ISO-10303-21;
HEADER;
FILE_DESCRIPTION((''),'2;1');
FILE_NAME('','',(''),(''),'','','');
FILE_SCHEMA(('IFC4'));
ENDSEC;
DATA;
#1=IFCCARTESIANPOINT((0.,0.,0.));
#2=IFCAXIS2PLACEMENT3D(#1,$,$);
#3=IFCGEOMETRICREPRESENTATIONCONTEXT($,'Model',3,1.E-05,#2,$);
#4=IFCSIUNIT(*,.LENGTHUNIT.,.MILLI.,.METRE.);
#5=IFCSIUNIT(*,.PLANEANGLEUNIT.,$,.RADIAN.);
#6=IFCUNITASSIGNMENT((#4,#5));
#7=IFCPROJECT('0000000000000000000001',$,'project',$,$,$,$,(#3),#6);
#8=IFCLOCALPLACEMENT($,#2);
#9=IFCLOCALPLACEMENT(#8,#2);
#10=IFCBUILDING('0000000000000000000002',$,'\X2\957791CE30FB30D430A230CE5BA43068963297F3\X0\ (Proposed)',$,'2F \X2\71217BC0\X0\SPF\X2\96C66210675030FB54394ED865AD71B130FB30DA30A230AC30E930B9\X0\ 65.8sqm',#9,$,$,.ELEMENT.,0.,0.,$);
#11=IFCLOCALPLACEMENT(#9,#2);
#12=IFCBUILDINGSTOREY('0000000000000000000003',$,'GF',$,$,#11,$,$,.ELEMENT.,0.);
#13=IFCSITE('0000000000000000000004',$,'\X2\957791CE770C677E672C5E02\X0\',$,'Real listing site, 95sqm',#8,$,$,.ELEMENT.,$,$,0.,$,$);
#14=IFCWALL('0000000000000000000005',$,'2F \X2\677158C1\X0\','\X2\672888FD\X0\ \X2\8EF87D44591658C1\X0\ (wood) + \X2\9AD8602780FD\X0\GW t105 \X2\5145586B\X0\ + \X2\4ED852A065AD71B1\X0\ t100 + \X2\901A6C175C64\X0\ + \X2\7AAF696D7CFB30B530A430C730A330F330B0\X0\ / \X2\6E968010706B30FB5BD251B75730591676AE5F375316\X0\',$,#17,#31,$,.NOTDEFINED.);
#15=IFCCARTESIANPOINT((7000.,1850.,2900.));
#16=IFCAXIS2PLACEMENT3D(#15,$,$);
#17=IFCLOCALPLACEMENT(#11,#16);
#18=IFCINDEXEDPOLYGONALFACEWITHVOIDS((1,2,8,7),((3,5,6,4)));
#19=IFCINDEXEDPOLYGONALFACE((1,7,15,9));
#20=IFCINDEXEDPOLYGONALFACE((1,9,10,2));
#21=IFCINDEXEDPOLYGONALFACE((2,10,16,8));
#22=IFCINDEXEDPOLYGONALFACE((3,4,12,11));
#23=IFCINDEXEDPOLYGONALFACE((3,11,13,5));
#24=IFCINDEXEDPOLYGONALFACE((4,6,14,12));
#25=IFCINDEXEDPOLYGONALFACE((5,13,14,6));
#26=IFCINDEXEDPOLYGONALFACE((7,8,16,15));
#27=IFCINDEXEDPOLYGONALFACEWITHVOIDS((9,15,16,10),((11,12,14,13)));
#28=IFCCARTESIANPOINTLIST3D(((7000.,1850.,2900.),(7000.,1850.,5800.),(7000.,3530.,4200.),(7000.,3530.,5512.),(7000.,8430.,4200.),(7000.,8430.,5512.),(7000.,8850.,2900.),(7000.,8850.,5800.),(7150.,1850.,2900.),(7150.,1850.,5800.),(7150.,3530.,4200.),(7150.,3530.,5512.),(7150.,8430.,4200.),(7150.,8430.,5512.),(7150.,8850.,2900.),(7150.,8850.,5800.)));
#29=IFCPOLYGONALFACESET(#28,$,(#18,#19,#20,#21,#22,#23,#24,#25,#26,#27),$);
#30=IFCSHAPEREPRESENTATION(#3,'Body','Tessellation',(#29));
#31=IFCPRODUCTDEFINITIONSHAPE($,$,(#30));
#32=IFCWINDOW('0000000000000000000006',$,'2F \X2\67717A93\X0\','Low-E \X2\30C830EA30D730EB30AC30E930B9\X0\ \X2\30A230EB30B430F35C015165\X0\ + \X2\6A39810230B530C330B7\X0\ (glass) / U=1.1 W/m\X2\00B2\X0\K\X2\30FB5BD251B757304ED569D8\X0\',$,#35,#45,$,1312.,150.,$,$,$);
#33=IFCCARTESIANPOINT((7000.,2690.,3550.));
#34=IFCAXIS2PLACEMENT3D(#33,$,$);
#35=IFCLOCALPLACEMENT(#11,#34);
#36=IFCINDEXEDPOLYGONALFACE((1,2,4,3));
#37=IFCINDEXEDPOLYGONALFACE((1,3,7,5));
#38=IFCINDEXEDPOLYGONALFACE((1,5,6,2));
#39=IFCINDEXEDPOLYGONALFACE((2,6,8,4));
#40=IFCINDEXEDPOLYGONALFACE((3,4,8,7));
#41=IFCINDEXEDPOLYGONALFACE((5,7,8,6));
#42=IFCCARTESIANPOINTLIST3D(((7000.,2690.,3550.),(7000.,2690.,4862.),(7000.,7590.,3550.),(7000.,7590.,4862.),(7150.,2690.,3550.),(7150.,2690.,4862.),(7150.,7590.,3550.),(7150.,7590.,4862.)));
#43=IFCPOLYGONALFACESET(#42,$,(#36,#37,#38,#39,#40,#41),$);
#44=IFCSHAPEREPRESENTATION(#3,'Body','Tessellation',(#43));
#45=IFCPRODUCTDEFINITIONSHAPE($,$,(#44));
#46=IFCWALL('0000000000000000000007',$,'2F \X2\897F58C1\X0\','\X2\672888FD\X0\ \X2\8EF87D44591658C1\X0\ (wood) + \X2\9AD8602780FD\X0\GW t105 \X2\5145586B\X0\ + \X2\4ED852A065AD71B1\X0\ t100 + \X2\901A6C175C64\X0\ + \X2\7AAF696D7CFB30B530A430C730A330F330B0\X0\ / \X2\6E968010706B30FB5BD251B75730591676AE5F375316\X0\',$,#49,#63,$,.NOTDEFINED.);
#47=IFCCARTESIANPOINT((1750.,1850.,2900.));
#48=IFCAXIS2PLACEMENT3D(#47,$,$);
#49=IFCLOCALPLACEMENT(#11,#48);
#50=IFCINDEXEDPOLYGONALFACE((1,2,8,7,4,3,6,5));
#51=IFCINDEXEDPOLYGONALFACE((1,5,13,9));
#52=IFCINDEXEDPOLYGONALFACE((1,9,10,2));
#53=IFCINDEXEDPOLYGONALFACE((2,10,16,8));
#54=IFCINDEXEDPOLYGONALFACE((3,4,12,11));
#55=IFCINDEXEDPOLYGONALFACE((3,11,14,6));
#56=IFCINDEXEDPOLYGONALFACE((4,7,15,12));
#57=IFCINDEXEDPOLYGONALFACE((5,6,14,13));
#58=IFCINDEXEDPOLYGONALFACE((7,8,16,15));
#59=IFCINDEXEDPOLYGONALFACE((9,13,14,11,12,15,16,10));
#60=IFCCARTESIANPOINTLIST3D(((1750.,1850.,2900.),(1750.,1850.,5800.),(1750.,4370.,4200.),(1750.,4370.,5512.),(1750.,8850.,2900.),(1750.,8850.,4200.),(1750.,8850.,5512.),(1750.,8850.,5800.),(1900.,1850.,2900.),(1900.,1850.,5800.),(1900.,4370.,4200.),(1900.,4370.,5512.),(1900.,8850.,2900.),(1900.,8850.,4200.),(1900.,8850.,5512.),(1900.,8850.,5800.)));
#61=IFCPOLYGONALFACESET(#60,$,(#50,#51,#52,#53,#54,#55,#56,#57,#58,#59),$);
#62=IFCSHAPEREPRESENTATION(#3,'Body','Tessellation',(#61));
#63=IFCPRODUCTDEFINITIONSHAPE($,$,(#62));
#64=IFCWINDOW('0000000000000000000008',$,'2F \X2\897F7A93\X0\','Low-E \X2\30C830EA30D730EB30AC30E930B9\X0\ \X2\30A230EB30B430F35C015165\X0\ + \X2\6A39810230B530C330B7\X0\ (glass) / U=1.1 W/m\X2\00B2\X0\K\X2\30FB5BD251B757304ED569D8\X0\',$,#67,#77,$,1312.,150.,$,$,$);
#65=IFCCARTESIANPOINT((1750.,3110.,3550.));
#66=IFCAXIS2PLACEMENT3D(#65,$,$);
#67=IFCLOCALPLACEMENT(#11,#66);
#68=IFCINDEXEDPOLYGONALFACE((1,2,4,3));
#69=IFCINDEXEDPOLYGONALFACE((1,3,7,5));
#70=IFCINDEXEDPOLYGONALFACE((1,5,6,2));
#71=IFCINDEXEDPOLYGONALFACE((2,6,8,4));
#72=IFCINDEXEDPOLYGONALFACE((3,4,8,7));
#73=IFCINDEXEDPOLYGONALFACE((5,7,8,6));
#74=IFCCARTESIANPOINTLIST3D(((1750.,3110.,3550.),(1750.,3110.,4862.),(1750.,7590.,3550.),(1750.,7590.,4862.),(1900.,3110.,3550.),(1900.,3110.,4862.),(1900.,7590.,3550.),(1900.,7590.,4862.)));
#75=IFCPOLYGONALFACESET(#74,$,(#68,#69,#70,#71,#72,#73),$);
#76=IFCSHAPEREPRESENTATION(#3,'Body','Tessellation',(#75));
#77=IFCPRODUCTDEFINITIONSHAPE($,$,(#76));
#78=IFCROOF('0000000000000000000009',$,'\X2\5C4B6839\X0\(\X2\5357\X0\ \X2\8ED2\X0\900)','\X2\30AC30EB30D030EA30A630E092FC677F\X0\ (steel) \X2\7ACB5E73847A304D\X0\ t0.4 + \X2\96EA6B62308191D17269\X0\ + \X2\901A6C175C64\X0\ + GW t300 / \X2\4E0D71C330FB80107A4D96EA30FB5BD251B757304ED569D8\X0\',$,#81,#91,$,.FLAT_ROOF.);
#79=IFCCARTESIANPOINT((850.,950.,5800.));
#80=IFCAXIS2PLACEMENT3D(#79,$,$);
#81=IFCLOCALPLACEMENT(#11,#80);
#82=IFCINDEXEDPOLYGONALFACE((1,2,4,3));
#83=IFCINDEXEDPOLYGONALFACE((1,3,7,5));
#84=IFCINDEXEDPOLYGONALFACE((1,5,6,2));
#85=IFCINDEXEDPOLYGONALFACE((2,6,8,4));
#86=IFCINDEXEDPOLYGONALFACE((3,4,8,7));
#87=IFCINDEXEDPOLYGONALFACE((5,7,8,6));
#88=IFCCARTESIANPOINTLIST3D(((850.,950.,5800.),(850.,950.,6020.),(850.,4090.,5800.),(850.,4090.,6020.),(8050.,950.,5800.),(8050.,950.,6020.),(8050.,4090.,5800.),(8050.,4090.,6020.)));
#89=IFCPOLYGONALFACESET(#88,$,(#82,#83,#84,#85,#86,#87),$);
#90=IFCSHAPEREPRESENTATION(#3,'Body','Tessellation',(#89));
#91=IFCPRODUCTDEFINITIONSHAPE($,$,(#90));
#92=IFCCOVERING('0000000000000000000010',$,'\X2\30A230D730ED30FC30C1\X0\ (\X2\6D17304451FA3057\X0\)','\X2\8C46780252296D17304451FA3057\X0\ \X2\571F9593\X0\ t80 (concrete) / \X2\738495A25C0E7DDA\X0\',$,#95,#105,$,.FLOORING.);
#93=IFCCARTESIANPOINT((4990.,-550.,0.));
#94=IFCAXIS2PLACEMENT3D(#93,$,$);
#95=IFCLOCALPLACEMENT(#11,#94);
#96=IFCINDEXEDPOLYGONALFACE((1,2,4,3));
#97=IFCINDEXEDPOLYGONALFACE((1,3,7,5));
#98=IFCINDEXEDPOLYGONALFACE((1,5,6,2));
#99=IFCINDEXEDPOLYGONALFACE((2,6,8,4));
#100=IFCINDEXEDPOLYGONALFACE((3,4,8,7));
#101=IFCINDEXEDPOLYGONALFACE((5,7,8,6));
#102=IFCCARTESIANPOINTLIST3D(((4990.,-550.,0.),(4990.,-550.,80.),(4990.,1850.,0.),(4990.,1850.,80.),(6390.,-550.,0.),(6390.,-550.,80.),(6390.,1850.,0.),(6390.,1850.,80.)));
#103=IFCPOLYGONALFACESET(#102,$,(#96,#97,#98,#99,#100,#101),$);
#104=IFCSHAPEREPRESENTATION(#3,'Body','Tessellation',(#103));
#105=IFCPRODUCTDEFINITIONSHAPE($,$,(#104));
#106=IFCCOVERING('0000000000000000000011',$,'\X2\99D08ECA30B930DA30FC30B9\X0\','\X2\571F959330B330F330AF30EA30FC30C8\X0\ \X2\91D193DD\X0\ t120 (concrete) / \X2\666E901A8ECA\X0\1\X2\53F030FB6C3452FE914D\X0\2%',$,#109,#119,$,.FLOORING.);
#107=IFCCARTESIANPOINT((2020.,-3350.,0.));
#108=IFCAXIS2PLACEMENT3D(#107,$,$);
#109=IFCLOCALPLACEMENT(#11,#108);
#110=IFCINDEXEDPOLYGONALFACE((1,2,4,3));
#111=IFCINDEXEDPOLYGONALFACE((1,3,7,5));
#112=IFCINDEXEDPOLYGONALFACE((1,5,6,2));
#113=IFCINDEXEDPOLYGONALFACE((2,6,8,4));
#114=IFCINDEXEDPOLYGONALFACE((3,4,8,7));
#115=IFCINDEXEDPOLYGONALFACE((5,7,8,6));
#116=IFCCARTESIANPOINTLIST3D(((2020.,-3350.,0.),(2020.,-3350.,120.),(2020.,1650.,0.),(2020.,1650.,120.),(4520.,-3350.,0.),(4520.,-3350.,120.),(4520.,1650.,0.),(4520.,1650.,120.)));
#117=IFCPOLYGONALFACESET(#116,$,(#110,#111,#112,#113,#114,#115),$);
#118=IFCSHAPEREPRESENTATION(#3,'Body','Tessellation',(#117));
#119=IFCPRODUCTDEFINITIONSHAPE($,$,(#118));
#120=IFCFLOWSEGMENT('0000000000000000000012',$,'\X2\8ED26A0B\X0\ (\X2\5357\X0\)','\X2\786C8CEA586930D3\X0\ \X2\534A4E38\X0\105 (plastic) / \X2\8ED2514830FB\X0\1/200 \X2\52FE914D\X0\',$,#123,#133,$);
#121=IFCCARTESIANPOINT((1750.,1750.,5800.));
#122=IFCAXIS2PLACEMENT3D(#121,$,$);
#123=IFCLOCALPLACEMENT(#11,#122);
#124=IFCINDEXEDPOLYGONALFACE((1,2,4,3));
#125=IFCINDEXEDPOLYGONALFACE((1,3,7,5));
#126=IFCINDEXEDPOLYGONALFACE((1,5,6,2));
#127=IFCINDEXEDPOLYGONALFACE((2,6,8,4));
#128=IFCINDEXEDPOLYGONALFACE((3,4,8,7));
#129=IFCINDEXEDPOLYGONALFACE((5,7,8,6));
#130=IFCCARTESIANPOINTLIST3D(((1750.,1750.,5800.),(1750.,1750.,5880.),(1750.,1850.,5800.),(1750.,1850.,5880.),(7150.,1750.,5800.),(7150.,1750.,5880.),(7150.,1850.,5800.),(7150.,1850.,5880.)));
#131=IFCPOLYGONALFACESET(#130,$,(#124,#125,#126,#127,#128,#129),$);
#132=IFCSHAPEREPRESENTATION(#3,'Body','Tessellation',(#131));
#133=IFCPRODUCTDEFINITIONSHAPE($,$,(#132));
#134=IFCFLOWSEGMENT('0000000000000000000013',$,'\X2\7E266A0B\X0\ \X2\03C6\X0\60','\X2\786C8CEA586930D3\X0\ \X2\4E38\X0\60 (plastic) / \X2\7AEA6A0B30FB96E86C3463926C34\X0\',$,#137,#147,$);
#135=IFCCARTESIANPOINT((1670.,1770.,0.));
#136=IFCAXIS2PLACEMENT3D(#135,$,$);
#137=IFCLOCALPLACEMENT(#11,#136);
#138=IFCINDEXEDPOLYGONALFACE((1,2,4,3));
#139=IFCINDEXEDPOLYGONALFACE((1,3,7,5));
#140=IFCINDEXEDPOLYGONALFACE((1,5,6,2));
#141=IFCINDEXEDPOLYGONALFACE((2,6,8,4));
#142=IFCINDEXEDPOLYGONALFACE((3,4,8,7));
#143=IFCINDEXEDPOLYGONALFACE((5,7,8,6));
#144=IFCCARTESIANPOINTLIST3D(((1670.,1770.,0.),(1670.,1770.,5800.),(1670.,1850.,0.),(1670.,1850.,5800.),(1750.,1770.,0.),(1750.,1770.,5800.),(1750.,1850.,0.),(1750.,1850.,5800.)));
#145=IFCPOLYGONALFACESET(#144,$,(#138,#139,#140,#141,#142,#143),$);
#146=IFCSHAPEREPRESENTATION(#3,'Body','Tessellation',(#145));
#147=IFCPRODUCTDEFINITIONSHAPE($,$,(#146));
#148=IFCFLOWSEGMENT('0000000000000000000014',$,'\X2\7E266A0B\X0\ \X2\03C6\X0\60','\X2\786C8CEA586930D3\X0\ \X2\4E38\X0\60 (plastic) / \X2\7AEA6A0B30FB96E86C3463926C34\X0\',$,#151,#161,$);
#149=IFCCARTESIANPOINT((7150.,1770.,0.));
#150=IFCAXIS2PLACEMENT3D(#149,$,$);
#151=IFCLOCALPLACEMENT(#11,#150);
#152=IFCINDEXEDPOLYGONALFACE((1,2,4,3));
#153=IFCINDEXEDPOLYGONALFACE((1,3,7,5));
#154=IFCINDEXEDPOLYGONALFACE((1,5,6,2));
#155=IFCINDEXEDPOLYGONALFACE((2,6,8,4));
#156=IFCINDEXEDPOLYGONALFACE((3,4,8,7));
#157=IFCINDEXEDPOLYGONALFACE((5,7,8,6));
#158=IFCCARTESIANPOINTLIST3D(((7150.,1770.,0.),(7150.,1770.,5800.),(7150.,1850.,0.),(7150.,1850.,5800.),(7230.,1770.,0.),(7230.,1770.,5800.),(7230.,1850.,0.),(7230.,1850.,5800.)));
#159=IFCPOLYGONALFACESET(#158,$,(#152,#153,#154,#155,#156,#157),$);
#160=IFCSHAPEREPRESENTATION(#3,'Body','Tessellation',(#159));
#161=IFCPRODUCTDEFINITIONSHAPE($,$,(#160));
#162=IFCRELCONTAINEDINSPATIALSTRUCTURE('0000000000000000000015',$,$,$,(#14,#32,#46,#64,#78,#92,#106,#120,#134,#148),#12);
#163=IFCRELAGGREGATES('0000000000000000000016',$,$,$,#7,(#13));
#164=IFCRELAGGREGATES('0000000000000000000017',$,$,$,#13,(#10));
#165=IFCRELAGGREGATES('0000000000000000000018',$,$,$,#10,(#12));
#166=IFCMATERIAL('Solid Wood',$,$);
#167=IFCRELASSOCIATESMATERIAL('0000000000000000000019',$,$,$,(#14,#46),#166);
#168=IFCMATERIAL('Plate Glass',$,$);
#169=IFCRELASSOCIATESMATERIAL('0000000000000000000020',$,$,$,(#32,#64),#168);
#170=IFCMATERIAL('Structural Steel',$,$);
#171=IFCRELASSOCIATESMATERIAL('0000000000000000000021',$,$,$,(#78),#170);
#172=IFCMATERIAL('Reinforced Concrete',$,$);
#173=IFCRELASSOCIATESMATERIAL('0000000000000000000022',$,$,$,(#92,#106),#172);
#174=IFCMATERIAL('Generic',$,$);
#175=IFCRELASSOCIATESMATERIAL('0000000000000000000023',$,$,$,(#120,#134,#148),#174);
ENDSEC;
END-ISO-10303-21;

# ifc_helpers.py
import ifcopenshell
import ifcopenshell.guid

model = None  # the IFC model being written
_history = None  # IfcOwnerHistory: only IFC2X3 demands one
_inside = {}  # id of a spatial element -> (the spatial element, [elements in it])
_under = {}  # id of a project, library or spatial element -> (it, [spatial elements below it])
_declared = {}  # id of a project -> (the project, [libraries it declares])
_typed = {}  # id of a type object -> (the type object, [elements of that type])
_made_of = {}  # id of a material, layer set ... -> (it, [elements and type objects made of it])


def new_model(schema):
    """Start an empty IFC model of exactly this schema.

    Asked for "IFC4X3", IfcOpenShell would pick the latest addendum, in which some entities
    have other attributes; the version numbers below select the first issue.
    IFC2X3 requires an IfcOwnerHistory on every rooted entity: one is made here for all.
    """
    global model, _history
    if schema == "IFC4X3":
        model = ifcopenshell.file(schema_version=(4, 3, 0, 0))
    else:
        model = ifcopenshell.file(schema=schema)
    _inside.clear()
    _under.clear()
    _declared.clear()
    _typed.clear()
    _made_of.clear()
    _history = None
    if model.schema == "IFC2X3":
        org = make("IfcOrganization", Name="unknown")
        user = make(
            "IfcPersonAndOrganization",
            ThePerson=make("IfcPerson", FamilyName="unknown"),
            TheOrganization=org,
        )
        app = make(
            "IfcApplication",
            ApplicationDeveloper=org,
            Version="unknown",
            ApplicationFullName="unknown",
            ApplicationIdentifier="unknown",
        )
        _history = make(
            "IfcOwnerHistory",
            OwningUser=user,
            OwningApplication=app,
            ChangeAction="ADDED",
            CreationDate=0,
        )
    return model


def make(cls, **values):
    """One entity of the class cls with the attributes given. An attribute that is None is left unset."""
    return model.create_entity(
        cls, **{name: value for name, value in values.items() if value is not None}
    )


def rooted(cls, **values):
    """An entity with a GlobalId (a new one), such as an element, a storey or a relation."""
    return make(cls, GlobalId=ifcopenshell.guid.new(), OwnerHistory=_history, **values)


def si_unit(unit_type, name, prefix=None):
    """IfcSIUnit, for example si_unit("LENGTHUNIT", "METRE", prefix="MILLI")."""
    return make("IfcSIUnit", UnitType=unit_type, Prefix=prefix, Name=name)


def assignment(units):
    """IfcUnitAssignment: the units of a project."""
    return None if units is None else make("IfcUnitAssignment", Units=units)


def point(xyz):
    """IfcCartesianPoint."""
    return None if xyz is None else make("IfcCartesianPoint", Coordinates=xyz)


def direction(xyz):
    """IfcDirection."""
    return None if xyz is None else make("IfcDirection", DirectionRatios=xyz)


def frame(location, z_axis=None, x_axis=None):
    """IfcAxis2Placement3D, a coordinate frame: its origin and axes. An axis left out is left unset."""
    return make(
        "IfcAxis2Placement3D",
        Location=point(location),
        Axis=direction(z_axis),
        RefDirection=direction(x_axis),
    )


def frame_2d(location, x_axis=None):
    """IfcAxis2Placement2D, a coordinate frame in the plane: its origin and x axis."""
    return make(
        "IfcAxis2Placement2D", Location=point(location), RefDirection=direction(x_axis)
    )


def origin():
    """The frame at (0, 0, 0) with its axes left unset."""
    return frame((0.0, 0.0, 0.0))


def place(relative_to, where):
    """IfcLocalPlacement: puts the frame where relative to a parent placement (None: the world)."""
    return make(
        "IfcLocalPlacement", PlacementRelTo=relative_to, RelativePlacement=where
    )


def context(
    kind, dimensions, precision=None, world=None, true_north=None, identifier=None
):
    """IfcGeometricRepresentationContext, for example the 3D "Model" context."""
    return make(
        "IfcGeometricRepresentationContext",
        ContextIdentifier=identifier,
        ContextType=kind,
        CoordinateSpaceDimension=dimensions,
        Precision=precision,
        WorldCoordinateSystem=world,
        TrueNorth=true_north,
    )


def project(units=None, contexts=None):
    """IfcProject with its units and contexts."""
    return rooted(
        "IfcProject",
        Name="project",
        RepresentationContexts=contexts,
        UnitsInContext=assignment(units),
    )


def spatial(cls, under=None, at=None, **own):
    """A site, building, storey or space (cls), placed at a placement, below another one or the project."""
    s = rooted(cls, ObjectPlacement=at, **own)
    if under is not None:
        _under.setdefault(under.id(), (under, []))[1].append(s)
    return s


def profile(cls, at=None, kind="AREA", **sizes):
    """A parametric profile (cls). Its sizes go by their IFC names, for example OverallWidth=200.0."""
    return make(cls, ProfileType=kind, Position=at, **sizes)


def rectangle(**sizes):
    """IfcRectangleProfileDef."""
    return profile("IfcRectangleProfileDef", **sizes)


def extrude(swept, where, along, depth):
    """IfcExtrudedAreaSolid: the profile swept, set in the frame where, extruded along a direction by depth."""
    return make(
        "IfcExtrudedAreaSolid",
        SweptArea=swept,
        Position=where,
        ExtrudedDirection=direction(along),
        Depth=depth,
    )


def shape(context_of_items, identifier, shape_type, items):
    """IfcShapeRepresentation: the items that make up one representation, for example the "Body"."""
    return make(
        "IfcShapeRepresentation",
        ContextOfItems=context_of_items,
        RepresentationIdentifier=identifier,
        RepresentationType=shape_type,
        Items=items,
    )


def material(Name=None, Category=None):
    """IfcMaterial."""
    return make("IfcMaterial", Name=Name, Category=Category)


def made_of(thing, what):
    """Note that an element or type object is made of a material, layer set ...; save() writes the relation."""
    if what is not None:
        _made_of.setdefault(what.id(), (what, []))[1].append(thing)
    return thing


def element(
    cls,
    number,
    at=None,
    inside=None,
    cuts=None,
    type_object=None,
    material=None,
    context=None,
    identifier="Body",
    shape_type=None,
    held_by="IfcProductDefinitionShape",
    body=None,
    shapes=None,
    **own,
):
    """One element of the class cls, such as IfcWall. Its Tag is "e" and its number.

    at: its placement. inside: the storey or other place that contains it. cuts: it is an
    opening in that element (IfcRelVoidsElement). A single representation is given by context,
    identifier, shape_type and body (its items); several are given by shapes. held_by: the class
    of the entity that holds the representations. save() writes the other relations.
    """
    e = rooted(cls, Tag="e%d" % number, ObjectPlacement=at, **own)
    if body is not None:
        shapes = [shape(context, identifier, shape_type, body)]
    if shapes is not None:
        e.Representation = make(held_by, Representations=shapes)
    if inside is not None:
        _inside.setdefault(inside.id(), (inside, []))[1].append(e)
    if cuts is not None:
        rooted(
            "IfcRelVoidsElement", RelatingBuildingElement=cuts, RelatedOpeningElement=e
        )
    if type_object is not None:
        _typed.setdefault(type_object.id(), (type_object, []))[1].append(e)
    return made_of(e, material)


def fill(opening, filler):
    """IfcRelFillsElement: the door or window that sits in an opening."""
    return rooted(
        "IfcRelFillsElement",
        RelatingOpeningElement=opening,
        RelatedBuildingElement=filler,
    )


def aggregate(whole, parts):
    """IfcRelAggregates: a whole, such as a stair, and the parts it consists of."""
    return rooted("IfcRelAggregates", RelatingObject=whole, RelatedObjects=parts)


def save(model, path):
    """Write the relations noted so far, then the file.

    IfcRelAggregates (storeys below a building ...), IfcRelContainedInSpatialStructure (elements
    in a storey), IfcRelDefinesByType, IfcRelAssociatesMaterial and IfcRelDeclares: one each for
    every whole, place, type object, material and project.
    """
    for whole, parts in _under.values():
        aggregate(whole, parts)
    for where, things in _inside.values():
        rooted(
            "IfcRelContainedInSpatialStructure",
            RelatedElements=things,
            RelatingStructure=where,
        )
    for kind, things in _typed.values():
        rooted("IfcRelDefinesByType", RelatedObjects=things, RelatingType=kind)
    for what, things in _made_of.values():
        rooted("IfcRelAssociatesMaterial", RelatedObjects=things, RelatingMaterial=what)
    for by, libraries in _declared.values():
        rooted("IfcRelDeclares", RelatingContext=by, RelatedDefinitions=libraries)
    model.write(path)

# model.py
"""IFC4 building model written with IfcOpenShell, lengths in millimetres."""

from ifc_helpers import new_model, si_unit, frame, frame_2d, origin, place, context, project, spatial, rectangle, extrude, material, element, fill, save


model = new_model("IFC4")

# Units and contexts
model_context = context("Model", 3, precision=1e-05, world=origin())
ifc_project = project(units=[si_unit("LENGTHUNIT", "METRE", prefix="MILLI"), si_unit("PLANEANGLEUNIT", "RADIAN")], contexts=[model_context])

# Site, building, storey
site_placement = place(None, origin())
site = spatial("IfcSite", under=ifc_project, at=site_placement, Name="長野県松本市", ObjectType="Real listing site, 95sqm", CompositionType="ELEMENT", RefElevation=0.0)
building_placement = place(site_placement, origin())
building = spatial("IfcBuilding", under=site, at=building_placement, Name="長野・ピアノ室と防音 (Proposed)", ObjectType="2F 無節SPF集成材・吹付断熱・ペアガラス 65.8sqm", CompositionType="ELEMENT", ElevationOfRefHeight=0.0, ElevationOfTerrain=0.0)
storey_placement = place(building_placement, origin())
storey = spatial("IfcBuildingStorey", under=building, at=storey_placement, Name="GF", CompositionType="ELEMENT", Elevation=0.0)

# Shared definitions
ifc_material_1 = material(Name="Solid Wood")

# Shared definitions
ifc_material_2 = material(Name="Reinforced Concrete")

# Shared definitions
ifc_material_3 = material(Name="Plate Glass")

# Walls, openings, windows
wall_1_placement = place(storey_placement, frame((7000.0, 1850.0, 2900.0)))
wall_1 = element("IfcWall", 1, at=wall_1_placement, inside=storey, material=ifc_material_1, Name="2F 東壁", Description="木製 軸組外壁 (wood) + 高性能GW t105 充填 + 付加断熱 t100 + 通気層 + 窯業系サイディング / 準耐火・寒冷地外皮強化", PredefinedType="NOTDEFINED", context=model_context, shape_type="SweptSolid", body=[
    extrude(rectangle(XDim=150.0, YDim=7000.0, at=frame_2d((75.0, 3500.0))), frame((7000.0, 1850.0, 2900.0)), (0.0, 0.0, 1.0), 2900.0),
])
opening_1_placement = place(storey_placement, frame((7000.0, 2690.0, 3550.0)))
opening_1 = element("IfcOpeningElement", 2, at=opening_1_placement, cuts=wall_1, PredefinedType="NOTDEFINED", context=model_context, shape_type="SweptSolid", body=[
    extrude(rectangle(XDim=150.0, YDim=4900.0, at=frame_2d((75.0, 2450.0))), frame((7000.0, 2690.0, 3550.0)), (0.0, 0.0, 1.0), 1312.0),
])
window_1_placement = place(storey_placement, frame((7000.0, 2690.0, 3550.0)))
window_1 = element("IfcWindow", 3, at=window_1_placement, inside=storey, material=ifc_material_3, Name="2F 東窓", Description="Low-E トリプルガラス アルゴン封入 + 樹脂サッシ (glass) / U=1.1 W/m²K・寒冷地仕様", OverallHeight=1312.0, OverallWidth=150.0, context=model_context, shape_type="SweptSolid", body=[
    extrude(rectangle(XDim=150.0, YDim=4900.0, at=frame_2d((75.0, 2450.0))), frame((7000.0, 2690.0, 3550.0)), (0.0, 0.0, 1.0), 1312.0),
])
fill(opening_1, window_1)
wall_2_placement = place(storey_placement, frame((1750.0, 1850.0, 2900.0)))
wall_2 = element("IfcWall", 4, at=wall_2_placement, inside=storey, material=ifc_material_1, Name="2F 西壁", Description="木製 軸組外壁 (wood) + 高性能GW t105 充填 + 付加断熱 t100 + 通気層 + 窯業系サイディング / 準耐火・寒冷地外皮強化", PredefinedType="NOTDEFINED", context=model_context, shape_type="SweptSolid", body=[
    extrude(rectangle(XDim=150.0, YDim=7000.0, at=frame_2d((75.0, 3500.0))), frame((1750.0, 1850.0, 2900.0)), (0.0, 0.0, 1.0), 2900.0),
])
opening_2_placement = place(storey_placement, frame((1750.0, 3110.0, 3550.0)))
opening_2 = element("IfcOpeningElement", 5, at=opening_2_placement, cuts=wall_2, PredefinedType="NOTDEFINED", context=model_context, shape_type="SweptSolid", body=[
    extrude(rectangle(XDim=150.0, YDim=4480.0, at=frame_2d((75.0, 2240.0))), frame((1750.0, 3110.0, 3550.0)), (0.0, 0.0, 1.0), 1312.0),
])
window_2_placement = place(storey_placement, frame((1750.0, 3110.0, 3550.0)))
window_2 = element("IfcWindow", 6, at=window_2_placement, inside=storey, material=ifc_material_3, Name="2F 西窓", Description="Low-E トリプルガラス アルゴン封入 + 樹脂サッシ (glass) / U=1.1 W/m²K・寒冷地仕様", OverallHeight=1312.0, OverallWidth=150.0, context=model_context, shape_type="SweptSolid", body=[
    extrude(rectangle(XDim=150.0, YDim=4480.0, at=frame_2d((75.0, 2240.0))), frame((1750.0, 3110.0, 3550.0)), (0.0, 0.0, 1.0), 1312.0),
])
fill(opening_2, window_2)

# Roof
ifc_material_4 = material(Name="Structural Steel")
for number, where, name in (
    (7, (850.0, 950.0, 5800.0), "屋根(南 軒900)"),
):
    element("IfcRoof", number, at=place(storey_placement, frame(where)), inside=storey, material=ifc_material_4, Name=name, Description="ガルバリウム鋼板 (steel) 立平葺き t0.4 + 雪止め金物 + 通気層 + GW t300 / 不燃・耐積雪・寒冷地仕様", PredefinedType="FLAT_ROOF", context=model_context, shape_type="SweptSolid", body=[
        extrude(rectangle(XDim=7200.0, YDim=3140.0, at=frame_2d((3600.0, 1570.0))), frame((850.0, 950.0, 5800.0)), (0.0, 0.0, 1.0), 220.0),
    ])

# Coverings
covering_1_placement = place(storey_placement, frame((4990.0, -550.0, 0.0)))
element("IfcCovering", 8, at=covering_1_placement, inside=storey, material=ifc_material_2, Name="アプローチ (洗い出し)", Description="豆砂利洗い出し 土間 t80 (concrete) / 玄関導線", PredefinedType="FLOORING", context=model_context, shape_type="SweptSolid", body=[
    extrude(rectangle(XDim=1400.0, YDim=2400.0, at=frame_2d((700.0, 1200.0))), frame((4990.0, -550.0, 0.0)), (0.0, 0.0, 1.0), 80.0),
])
covering_2_placement = place(storey_placement, frame((2020.0, -3350.0, 0.0)))
element("IfcCovering", 9, at=covering_2_placement, inside=storey, material=ifc_material_2, Name="駐車スペース", Description="土間コンクリート 金鏝 t120 (concrete) / 普通車1台・水勾配2%", PredefinedType="FLOORING", context=model_context, shape_type="SweptSolid", body=[
    extrude(rectangle(XDim=2500.0, YDim=5000.0, at=frame_2d((1250.0, 2500.0))), frame((2020.0, -3350.0, 0.0)), (0.0, 0.0, 1.0), 120.0),
])

# Flow segments
ifc_material_5 = material(Name="Generic")
flow_segment_1_placement = place(storey_placement, frame((1750.0, 1750.0, 5800.0)))
element("IfcFlowSegment", 10, at=flow_segment_1_placement, inside=storey, material=ifc_material_5, Name="軒樋 (南)", Description="硬質塩ビ 半丸105 (plastic) / 軒先・1/200 勾配", context=model_context, shape_type="SweptSolid", body=[
    extrude(rectangle(XDim=5400.0, YDim=100.0, at=frame_2d((2700.0, 50.0))), frame((1750.0, 1750.0, 5800.0)), (0.0, 0.0, 1.0), 80.0),
])
flow_segment_2_placement = place(storey_placement, frame((1670.0, 1770.0, 0.0)))
element("IfcFlowSegment", 11, at=flow_segment_2_placement, inside=storey, material=ifc_material_5, Name="縦樋 φ60", Description="硬質塩ビ 丸60 (plastic) / 竪樋・雨水排水", context=model_context, shape_type="SweptSolid", body=[
    extrude(rectangle(XDim=80.0, YDim=80.0, at=frame_2d((40.0, 40.0))), frame((1670.0, 1770.0, 0.0)), (0.0, 0.0, 1.0), 5800.0),
])
flow_segment_3_placement = place(storey_placement, frame((7150.0, 1770.0, 0.0)))
element("IfcFlowSegment", 12, at=flow_segment_3_placement, inside=storey, material=ifc_material_5, Name="縦樋 φ60", Description="硬質塩ビ 丸60 (plastic) / 竪樋・雨水排水", context=model_context, shape_type="SweptSolid", body=[
    extrude(rectangle(XDim=80.0, YDim=80.0, at=frame_2d((40.0, 40.0))), frame((7150.0, 1770.0, 0.0)), (0.0, 0.0, 1.0), 5800.0),
])

save(model, "model.ifc")
